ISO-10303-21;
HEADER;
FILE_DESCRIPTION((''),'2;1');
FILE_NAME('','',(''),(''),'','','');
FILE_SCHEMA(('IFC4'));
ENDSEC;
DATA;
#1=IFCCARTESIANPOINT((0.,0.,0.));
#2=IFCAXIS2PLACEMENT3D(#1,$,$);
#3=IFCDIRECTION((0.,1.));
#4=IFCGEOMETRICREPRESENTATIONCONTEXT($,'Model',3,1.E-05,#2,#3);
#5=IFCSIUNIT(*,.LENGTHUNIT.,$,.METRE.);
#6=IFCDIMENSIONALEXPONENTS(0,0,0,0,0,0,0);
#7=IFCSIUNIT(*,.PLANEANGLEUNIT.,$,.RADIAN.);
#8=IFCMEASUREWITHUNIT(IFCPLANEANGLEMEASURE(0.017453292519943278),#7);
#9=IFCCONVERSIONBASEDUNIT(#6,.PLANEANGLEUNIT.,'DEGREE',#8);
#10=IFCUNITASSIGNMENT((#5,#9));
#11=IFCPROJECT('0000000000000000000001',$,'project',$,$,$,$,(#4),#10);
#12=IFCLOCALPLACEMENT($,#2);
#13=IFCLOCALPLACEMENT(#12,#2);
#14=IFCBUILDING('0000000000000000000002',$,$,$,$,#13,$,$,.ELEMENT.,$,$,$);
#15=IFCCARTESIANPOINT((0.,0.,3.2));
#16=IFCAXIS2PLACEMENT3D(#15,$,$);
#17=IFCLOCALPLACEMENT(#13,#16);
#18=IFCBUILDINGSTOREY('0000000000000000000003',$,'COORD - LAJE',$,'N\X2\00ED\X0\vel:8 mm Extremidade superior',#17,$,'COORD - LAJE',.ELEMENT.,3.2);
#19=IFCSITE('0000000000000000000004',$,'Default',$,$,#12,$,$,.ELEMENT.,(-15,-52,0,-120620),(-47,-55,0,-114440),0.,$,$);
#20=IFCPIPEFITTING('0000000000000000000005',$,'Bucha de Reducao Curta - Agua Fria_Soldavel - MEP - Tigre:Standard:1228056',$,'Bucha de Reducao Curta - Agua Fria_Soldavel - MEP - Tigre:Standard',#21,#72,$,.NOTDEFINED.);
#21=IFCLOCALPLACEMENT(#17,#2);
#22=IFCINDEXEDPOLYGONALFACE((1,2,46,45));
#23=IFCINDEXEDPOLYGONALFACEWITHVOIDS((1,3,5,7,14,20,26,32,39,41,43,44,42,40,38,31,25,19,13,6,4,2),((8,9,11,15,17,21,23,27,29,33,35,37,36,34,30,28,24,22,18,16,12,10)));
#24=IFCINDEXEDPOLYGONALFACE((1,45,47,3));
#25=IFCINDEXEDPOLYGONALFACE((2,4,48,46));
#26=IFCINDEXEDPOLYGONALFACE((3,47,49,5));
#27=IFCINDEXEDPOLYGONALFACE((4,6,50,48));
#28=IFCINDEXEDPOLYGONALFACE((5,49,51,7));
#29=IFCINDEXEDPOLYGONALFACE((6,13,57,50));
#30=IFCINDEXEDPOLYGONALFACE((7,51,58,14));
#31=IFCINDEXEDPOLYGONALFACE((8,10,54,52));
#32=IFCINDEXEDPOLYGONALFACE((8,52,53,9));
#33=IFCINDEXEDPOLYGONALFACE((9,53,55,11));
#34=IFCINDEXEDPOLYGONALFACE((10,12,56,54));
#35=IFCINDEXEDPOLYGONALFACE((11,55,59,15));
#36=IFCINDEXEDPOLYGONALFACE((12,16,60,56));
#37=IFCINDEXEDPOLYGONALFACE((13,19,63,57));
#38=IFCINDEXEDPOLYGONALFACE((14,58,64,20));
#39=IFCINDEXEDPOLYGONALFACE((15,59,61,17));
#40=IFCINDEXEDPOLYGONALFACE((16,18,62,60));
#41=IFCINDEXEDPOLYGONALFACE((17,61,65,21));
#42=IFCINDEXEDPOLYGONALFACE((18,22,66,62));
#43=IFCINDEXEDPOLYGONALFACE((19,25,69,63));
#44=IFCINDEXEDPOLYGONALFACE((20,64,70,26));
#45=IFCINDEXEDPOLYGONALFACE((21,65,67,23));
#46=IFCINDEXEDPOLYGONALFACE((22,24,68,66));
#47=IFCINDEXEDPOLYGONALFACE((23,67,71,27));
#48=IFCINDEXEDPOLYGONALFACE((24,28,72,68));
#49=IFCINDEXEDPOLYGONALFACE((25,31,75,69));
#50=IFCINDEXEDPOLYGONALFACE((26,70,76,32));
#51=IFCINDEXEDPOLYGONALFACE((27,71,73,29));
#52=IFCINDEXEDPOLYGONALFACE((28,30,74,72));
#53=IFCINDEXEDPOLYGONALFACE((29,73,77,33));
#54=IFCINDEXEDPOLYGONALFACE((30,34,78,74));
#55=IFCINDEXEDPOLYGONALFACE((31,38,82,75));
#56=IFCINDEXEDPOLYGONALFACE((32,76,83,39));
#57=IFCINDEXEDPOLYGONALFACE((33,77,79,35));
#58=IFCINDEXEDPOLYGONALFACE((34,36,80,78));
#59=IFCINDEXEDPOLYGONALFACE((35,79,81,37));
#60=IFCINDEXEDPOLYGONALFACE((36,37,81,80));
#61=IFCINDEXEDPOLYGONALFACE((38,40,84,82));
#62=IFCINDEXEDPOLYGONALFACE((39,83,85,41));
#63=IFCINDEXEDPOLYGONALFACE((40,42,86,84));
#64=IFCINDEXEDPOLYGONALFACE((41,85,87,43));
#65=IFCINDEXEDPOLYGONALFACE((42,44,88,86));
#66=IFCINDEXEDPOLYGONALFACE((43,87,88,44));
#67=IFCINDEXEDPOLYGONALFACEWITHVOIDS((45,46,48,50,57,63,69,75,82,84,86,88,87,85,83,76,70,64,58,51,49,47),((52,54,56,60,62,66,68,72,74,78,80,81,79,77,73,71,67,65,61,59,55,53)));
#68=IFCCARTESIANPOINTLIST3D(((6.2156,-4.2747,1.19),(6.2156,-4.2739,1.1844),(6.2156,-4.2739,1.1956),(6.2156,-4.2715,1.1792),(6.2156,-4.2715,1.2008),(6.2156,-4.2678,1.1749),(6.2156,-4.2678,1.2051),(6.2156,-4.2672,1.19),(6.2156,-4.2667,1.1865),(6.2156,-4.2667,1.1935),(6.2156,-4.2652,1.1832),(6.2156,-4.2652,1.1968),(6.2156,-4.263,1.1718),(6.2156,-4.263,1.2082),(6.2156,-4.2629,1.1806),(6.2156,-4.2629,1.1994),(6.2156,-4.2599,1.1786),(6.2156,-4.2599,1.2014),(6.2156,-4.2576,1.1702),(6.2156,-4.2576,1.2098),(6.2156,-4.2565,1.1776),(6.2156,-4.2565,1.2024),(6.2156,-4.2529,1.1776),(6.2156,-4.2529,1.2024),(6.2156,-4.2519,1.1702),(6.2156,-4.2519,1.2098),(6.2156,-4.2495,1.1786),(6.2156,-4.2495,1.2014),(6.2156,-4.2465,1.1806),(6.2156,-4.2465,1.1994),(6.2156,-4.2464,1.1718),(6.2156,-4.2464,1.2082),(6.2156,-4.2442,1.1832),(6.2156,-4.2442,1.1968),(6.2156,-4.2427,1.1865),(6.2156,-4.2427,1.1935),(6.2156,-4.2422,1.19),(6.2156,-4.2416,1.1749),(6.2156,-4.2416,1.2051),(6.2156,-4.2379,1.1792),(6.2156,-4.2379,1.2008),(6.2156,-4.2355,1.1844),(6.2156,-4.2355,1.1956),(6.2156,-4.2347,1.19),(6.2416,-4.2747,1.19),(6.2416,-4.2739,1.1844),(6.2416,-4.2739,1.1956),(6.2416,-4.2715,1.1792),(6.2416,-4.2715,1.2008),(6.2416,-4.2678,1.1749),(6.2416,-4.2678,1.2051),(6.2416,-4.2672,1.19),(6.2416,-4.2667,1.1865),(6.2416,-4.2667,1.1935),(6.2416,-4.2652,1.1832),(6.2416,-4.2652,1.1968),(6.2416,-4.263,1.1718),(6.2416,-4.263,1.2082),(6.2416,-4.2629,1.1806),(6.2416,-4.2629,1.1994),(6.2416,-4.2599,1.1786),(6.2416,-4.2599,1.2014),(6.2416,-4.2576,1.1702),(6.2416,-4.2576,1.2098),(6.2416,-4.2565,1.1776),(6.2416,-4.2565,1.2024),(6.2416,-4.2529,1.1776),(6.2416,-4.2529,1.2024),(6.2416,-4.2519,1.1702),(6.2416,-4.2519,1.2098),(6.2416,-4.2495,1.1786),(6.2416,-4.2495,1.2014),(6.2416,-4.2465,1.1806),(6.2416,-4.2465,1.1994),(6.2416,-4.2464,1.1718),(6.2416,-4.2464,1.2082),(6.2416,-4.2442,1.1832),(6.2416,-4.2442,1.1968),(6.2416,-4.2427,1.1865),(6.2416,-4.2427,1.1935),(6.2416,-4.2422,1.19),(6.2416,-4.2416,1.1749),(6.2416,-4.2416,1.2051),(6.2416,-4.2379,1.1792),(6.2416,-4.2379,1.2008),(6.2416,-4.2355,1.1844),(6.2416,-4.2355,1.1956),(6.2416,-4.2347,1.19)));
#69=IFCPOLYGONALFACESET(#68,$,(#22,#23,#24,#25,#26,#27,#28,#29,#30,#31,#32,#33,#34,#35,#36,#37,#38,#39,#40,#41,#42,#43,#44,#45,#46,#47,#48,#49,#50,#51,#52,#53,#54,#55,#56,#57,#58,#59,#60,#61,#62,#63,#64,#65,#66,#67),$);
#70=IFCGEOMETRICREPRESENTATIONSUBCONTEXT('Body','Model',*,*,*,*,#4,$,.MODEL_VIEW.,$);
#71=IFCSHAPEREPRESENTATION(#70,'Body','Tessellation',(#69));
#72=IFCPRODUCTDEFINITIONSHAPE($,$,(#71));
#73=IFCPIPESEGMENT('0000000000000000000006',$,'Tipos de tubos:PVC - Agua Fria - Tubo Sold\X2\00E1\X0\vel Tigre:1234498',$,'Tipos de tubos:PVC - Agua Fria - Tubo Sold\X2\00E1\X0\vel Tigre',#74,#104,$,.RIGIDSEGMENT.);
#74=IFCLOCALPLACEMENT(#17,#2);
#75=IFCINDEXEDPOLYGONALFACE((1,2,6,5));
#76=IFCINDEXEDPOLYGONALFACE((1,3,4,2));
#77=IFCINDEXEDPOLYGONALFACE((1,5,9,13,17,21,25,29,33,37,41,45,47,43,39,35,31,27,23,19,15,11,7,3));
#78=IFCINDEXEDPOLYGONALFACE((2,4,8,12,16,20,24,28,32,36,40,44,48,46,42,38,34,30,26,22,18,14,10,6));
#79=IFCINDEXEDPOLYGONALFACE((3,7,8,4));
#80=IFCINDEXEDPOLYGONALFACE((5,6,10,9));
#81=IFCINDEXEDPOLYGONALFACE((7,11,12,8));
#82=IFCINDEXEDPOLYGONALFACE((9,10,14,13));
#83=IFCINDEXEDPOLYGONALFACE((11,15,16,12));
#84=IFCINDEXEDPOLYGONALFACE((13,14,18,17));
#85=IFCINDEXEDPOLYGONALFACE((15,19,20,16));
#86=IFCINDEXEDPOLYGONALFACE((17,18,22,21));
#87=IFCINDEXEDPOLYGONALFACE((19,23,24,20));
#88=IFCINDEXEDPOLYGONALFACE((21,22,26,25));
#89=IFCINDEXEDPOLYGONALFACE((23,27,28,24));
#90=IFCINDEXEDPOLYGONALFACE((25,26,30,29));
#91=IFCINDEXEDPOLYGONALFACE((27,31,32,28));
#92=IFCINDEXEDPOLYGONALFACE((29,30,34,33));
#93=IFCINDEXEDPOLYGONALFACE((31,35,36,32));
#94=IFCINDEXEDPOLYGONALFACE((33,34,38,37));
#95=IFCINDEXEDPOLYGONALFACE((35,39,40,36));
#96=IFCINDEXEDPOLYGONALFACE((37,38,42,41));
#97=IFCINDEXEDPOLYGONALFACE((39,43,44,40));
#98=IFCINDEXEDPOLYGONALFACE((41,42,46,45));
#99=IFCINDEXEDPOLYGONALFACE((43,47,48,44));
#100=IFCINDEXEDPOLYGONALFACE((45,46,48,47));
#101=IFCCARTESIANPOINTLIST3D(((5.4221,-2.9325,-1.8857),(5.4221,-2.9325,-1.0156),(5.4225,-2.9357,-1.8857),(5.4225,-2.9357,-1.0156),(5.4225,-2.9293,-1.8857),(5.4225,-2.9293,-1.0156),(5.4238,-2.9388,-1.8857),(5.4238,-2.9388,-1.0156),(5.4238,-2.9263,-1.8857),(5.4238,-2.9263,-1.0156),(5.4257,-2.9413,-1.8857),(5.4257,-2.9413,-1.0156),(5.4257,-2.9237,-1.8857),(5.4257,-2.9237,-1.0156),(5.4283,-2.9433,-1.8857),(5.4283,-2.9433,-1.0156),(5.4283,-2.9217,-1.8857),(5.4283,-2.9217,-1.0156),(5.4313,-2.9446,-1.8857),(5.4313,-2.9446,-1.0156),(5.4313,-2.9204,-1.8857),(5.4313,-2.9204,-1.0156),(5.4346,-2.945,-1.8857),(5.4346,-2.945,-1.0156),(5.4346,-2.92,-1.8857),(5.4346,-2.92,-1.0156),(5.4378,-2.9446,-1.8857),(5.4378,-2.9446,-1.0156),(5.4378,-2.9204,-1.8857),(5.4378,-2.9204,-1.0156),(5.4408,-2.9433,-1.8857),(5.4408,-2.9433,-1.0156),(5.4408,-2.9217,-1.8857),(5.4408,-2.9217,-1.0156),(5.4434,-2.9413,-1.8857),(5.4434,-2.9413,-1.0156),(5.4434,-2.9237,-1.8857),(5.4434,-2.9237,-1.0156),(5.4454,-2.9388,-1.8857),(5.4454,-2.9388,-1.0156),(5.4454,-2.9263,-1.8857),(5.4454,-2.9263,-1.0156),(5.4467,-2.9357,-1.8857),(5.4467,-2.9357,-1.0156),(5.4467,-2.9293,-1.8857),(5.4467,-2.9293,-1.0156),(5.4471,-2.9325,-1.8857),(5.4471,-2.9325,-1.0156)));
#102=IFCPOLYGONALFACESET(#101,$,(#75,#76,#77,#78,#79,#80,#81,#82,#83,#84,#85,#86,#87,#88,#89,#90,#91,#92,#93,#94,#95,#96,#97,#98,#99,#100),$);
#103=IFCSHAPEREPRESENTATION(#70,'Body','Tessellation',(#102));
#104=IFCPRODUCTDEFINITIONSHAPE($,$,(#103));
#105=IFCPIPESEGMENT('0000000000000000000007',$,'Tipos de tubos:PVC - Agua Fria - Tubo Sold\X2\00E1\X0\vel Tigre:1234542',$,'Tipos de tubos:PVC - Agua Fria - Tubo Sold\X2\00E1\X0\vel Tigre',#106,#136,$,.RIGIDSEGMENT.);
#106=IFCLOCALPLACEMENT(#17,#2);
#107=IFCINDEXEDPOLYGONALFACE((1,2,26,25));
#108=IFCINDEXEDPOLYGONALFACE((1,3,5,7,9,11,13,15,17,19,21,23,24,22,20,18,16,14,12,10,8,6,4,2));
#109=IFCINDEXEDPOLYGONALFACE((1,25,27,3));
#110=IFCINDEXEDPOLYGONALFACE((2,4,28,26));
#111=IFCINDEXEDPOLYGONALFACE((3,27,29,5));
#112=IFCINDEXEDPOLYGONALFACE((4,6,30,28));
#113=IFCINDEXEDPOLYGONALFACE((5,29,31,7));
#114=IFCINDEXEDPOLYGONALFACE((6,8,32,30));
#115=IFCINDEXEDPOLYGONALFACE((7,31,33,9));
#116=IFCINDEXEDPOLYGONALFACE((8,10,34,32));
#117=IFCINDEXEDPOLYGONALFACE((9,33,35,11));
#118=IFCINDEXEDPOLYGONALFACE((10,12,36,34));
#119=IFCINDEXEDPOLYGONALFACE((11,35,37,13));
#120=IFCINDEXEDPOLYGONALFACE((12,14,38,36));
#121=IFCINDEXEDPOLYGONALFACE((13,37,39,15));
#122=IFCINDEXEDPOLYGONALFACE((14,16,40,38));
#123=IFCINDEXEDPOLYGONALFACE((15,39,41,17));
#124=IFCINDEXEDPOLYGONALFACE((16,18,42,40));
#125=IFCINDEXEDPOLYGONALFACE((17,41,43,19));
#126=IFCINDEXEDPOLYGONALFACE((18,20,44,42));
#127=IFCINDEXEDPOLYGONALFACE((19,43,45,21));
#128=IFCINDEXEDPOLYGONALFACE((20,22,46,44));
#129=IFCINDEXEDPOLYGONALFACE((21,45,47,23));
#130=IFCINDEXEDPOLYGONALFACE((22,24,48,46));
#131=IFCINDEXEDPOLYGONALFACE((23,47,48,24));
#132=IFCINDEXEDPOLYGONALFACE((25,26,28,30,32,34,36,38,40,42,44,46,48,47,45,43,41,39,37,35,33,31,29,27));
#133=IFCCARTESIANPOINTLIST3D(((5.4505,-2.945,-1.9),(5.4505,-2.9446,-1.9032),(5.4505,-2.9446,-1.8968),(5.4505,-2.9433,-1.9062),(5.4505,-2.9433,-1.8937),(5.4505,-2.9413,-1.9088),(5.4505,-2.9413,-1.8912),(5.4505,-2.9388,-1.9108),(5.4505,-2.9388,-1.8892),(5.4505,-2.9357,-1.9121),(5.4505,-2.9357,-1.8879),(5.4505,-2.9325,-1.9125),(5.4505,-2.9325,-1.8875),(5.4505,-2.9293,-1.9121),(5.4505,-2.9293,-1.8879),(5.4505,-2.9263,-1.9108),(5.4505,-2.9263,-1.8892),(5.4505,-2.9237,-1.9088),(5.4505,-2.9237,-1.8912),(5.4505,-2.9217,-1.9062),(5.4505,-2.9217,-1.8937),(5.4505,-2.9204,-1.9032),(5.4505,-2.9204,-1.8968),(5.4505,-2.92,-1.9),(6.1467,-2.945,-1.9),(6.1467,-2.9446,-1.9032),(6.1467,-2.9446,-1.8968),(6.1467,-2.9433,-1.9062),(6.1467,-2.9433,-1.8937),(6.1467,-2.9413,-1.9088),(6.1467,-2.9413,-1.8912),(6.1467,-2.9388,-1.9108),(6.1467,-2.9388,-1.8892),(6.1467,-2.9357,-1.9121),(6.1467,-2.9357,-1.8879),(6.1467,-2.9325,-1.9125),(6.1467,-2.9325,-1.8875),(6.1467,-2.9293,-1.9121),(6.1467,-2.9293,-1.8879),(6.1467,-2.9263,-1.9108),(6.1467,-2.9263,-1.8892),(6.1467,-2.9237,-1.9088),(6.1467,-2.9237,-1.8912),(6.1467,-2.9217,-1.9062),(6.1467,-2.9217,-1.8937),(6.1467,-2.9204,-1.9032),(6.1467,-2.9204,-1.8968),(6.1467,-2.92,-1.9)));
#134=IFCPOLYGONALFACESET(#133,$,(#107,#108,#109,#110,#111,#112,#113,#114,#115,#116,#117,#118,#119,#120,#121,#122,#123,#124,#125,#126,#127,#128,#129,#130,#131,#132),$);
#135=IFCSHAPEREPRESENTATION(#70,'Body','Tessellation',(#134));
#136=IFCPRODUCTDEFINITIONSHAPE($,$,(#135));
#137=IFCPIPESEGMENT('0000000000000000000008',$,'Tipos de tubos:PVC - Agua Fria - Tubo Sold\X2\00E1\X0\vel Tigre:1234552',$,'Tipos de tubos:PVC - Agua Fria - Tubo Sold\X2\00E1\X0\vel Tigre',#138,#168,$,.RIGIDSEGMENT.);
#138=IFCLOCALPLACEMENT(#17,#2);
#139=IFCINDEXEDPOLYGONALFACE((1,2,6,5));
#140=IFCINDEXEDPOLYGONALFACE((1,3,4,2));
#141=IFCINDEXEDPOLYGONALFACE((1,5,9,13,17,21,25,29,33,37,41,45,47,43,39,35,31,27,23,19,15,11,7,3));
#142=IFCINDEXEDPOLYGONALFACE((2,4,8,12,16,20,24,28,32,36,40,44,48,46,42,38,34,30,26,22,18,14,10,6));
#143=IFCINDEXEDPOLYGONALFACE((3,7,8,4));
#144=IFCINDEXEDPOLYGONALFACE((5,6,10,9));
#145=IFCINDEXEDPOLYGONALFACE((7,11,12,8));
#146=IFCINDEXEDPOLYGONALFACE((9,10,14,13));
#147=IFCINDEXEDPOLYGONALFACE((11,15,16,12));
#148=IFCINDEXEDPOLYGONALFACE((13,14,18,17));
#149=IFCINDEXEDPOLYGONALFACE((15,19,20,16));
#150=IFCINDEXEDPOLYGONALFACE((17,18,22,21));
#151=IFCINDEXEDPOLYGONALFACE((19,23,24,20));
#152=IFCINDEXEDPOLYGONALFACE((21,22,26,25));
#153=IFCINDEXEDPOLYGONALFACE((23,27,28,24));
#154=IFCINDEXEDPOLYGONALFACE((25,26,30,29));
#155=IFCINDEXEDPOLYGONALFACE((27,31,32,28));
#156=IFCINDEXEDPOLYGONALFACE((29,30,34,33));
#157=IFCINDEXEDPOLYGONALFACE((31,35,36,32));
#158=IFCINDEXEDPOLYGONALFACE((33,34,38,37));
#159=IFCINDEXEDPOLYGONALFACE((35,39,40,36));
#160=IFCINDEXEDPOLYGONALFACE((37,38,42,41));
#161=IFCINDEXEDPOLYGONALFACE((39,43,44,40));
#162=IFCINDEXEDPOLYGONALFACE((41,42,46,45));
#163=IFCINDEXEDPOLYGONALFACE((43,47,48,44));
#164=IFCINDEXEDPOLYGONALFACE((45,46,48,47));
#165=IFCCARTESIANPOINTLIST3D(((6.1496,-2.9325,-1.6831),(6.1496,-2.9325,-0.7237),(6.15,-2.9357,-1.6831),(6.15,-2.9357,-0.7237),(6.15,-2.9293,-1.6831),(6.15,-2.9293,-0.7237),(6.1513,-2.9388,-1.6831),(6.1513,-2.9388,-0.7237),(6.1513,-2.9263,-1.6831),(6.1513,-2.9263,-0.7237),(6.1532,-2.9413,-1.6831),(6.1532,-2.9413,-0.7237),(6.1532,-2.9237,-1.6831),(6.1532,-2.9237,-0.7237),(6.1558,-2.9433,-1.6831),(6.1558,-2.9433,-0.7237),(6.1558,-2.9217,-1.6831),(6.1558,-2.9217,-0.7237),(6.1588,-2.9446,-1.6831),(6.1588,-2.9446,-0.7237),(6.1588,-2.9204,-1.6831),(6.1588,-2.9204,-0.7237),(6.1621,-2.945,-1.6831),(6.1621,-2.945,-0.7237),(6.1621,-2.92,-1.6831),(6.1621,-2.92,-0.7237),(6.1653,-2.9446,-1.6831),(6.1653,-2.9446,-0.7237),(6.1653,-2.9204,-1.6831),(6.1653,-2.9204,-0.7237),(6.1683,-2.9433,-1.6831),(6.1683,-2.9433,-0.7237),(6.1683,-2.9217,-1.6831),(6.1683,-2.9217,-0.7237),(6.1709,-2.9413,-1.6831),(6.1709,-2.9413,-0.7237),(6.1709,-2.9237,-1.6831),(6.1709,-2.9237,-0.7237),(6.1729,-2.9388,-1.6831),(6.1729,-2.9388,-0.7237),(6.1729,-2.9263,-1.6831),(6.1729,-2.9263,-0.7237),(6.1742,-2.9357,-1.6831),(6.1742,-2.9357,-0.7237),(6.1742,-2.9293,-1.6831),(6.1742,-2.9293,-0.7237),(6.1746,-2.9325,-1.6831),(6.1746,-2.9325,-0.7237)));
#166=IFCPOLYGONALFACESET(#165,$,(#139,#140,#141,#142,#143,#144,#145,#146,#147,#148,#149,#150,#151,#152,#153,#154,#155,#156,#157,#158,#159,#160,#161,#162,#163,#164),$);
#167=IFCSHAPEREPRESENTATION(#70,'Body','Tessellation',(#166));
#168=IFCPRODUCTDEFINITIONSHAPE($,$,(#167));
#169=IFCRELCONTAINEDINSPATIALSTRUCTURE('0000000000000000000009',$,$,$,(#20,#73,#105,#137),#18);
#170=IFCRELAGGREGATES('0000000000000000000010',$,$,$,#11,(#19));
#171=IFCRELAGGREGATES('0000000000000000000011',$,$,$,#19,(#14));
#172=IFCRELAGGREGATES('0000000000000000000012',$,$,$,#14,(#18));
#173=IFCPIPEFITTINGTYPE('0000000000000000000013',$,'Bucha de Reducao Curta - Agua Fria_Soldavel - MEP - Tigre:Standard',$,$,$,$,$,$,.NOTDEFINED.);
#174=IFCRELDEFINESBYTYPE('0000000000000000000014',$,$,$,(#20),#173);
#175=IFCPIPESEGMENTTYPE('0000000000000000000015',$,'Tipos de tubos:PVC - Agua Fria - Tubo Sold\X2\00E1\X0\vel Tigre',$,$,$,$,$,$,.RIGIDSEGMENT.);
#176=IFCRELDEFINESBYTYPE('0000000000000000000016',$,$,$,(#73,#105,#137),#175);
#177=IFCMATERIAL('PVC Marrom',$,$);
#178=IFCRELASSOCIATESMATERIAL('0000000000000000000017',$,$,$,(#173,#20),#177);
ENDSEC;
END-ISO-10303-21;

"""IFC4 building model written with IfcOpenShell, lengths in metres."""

from ifc_helpers import new_model, entity, si_unit, converted_unit, direction, frame, origin, place, context, subcontext, project, spatial, arc, indexed_curve, outline, extrude, source, transform, mapped, material, type_object, type_shapes, element, save


model = new_model("IFC4")

# Units and contexts
model_context = context("Model", 3, precision=1e-05, world=origin(), true_north=direction((0.0, 1.0)))
body_context = subcontext(model_context, "Body", "Model", "MODEL_VIEW")
ifc_project = project(units=[si_unit("LENGTHUNIT", "METRE"), converted_unit("PLANEANGLEUNIT", "DEGREE", entity("IfcPlaneAngleMeasure", 0.017453292519943278), si_unit("PLANEANGLEUNIT", "RADIAN"), dimensions=[0, 0, 0, 0, 0, 0, 0])], contexts=[model_context])

# Site, building, storey
site_placement = place(None, origin())
site = spatial("IfcSite", under=ifc_project, at=site_placement, Name="Default", CompositionType="ELEMENT", RefLatitude=(-15, -52, 0, -120620), RefLongitude=(-47, -55, 0, -114440), RefElevation=0.0)
building_placement = place(site_placement, origin())
building = spatial("IfcBuilding", under=site, at=building_placement, CompositionType="ELEMENT")
storey_placement = place(building_placement, frame((0.0, 0.0, 3.2)))
storey = spatial("IfcBuildingStorey", under=building, at=storey_placement, Name="COORD - LAJE", ObjectType="Nível:8 mm Extremidade superior", LongName="COORD - LAJE", CompositionType="ELEMENT", Elevation=3.2)

# Pipe fitting
ifc_material = material(Name="PVC Marrom")
pipe_fitting_type = type_object("IfcPipeFittingType", Name="Bucha de Reducao Curta - Agua Fria_Soldavel - MEP - Tigre:Standard", PredefinedType="NOTDEFINED", material=ifc_material)
shared_shape = source(origin(), body_context, "Body", "SweptSolid", [
    extrude(outline(indexed_curve([(-0.02, 0.0), (0.0, -0.02), (0.02, 0.0), (0.0, 0.02)], segments=[arc(1, 2, 3), arc(3, 4, 1)], self_intersect=False), holes=[indexed_curve([(-0.0125, 0.0), (0.0, 0.0125), (0.0125, 0.0), (0.0, -0.0125)], segments=[arc(1, 2, 3), arc(3, 4, 1)], self_intersect=False)]), frame((0.0, 0.0, 0.0), z_axis=(1.0, 0.0, 0.0), x_axis=(0.0, 1.0, 0.0)), (0.0, 0.0, 1.0), 0.026),
])
type_shapes(pipe_fitting_type, [shared_shape])
pipe_fitting_placement = place(storey_placement, frame((6.2156, -4.2547, 1.19)))
element("IfcPipeFitting", 1, at=pipe_fitting_placement, inside=storey, type_object=pipe_fitting_type, material=ifc_material, Name="Bucha de Reducao Curta - Agua Fria_Soldavel - MEP - Tigre:Standard:1228056", ObjectType="Bucha de Reducao Curta - Agua Fria_Soldavel - MEP - Tigre:Standard", PredefinedType="NOTDEFINED", context=body_context, shape_type="MappedRepresentation", body=[
    mapped(shared_shape, transform((0.0, 0.0, 0.0), scale=1.0)),
])

# Pipe segments
pipe_segment_type = type_object("IfcPipeSegmentType", Name="Tipos de tubos:PVC - Agua Fria - Tubo Soldável Tigre", PredefinedType="RIGIDSEGMENT")
pipe_segment_1_placement = place(storey_placement, origin())
element("IfcPipeSegment", 2, at=pipe_segment_1_placement, inside=storey, type_object=pipe_segment_type, Name="Tipos de tubos:PVC - Agua Fria - Tubo Soldável Tigre:1234498", ObjectType="Tipos de tubos:PVC - Agua Fria - Tubo Soldável Tigre", PredefinedType="RIGIDSEGMENT", context=body_context, shape_type="SweptSolid", body=[
    extrude(outline(indexed_curve([(0.0125, 0.0), (0.0088, 0.0088), (0.0, 0.0125), (-0.0088, 0.0088), (-0.0125, 0.0), (-0.0088, -0.0088), (0.0, -0.0125), (0.0088, -0.0088)], segments=[arc(1, 2, 3), arc(3, 4, 5), arc(5, 6, 7), arc(7, 8, 1)], self_intersect=False)), frame((5.4346, -2.9325, -1.8857)), (0.0, 0.0, 1.0), 0.8702),
])
pipe_segment_2_placement = place(storey_placement, origin())
element("IfcPipeSegment", 3, at=pipe_segment_2_placement, inside=storey, type_object=pipe_segment_type, Name="Tipos de tubos:PVC - Agua Fria - Tubo Soldável Tigre:1234542", ObjectType="Tipos de tubos:PVC - Agua Fria - Tubo Soldável Tigre", PredefinedType="RIGIDSEGMENT", context=body_context, shape_type="SweptSolid", body=[
    extrude(outline(indexed_curve([(0.0125, 0.0), (0.0088, 0.0088), (0.0, 0.0125), (-0.0088, 0.0088), (-0.0125, 0.0), (-0.0088, -0.0088), (0.0, -0.0125), (0.0088, -0.0088)], segments=[arc(1, 2, 3), arc(3, 4, 5), arc(5, 6, 7), arc(7, 8, 1)], self_intersect=False)), frame((5.4505, -2.9325, -1.9), z_axis=(1.0, 0.0, 0.0), x_axis=(0.0, -1.0, 0.0)), (0.0, 0.0, 1.0), 0.6962),
])
pipe_segment_3_placement = place(storey_placement, origin())
element("IfcPipeSegment", 4, at=pipe_segment_3_placement, inside=storey, type_object=pipe_segment_type, Name="Tipos de tubos:PVC - Agua Fria - Tubo Soldável Tigre:1234552", ObjectType="Tipos de tubos:PVC - Agua Fria - Tubo Soldável Tigre", PredefinedType="RIGIDSEGMENT", context=body_context, shape_type="SweptSolid", body=[
    extrude(outline(indexed_curve([(0.0125, 0.0), (0.0088, 0.0088), (0.0, 0.0125), (-0.0088, 0.0088), (-0.0125, 0.0), (-0.0088, -0.0088), (0.0, -0.0125), (0.0088, -0.0088)], segments=[arc(1, 2, 3), arc(3, 4, 5), arc(5, 6, 7), arc(7, 8, 1)], self_intersect=False)), frame((6.1621, -2.9325, -1.6831), z_axis=(0.0, 0.0, 1.0), x_axis=(-1.0, 0.0, 0.0)), (0.0, 0.0, 1.0), 0.9594),
])

save(model, "model.ifc")
